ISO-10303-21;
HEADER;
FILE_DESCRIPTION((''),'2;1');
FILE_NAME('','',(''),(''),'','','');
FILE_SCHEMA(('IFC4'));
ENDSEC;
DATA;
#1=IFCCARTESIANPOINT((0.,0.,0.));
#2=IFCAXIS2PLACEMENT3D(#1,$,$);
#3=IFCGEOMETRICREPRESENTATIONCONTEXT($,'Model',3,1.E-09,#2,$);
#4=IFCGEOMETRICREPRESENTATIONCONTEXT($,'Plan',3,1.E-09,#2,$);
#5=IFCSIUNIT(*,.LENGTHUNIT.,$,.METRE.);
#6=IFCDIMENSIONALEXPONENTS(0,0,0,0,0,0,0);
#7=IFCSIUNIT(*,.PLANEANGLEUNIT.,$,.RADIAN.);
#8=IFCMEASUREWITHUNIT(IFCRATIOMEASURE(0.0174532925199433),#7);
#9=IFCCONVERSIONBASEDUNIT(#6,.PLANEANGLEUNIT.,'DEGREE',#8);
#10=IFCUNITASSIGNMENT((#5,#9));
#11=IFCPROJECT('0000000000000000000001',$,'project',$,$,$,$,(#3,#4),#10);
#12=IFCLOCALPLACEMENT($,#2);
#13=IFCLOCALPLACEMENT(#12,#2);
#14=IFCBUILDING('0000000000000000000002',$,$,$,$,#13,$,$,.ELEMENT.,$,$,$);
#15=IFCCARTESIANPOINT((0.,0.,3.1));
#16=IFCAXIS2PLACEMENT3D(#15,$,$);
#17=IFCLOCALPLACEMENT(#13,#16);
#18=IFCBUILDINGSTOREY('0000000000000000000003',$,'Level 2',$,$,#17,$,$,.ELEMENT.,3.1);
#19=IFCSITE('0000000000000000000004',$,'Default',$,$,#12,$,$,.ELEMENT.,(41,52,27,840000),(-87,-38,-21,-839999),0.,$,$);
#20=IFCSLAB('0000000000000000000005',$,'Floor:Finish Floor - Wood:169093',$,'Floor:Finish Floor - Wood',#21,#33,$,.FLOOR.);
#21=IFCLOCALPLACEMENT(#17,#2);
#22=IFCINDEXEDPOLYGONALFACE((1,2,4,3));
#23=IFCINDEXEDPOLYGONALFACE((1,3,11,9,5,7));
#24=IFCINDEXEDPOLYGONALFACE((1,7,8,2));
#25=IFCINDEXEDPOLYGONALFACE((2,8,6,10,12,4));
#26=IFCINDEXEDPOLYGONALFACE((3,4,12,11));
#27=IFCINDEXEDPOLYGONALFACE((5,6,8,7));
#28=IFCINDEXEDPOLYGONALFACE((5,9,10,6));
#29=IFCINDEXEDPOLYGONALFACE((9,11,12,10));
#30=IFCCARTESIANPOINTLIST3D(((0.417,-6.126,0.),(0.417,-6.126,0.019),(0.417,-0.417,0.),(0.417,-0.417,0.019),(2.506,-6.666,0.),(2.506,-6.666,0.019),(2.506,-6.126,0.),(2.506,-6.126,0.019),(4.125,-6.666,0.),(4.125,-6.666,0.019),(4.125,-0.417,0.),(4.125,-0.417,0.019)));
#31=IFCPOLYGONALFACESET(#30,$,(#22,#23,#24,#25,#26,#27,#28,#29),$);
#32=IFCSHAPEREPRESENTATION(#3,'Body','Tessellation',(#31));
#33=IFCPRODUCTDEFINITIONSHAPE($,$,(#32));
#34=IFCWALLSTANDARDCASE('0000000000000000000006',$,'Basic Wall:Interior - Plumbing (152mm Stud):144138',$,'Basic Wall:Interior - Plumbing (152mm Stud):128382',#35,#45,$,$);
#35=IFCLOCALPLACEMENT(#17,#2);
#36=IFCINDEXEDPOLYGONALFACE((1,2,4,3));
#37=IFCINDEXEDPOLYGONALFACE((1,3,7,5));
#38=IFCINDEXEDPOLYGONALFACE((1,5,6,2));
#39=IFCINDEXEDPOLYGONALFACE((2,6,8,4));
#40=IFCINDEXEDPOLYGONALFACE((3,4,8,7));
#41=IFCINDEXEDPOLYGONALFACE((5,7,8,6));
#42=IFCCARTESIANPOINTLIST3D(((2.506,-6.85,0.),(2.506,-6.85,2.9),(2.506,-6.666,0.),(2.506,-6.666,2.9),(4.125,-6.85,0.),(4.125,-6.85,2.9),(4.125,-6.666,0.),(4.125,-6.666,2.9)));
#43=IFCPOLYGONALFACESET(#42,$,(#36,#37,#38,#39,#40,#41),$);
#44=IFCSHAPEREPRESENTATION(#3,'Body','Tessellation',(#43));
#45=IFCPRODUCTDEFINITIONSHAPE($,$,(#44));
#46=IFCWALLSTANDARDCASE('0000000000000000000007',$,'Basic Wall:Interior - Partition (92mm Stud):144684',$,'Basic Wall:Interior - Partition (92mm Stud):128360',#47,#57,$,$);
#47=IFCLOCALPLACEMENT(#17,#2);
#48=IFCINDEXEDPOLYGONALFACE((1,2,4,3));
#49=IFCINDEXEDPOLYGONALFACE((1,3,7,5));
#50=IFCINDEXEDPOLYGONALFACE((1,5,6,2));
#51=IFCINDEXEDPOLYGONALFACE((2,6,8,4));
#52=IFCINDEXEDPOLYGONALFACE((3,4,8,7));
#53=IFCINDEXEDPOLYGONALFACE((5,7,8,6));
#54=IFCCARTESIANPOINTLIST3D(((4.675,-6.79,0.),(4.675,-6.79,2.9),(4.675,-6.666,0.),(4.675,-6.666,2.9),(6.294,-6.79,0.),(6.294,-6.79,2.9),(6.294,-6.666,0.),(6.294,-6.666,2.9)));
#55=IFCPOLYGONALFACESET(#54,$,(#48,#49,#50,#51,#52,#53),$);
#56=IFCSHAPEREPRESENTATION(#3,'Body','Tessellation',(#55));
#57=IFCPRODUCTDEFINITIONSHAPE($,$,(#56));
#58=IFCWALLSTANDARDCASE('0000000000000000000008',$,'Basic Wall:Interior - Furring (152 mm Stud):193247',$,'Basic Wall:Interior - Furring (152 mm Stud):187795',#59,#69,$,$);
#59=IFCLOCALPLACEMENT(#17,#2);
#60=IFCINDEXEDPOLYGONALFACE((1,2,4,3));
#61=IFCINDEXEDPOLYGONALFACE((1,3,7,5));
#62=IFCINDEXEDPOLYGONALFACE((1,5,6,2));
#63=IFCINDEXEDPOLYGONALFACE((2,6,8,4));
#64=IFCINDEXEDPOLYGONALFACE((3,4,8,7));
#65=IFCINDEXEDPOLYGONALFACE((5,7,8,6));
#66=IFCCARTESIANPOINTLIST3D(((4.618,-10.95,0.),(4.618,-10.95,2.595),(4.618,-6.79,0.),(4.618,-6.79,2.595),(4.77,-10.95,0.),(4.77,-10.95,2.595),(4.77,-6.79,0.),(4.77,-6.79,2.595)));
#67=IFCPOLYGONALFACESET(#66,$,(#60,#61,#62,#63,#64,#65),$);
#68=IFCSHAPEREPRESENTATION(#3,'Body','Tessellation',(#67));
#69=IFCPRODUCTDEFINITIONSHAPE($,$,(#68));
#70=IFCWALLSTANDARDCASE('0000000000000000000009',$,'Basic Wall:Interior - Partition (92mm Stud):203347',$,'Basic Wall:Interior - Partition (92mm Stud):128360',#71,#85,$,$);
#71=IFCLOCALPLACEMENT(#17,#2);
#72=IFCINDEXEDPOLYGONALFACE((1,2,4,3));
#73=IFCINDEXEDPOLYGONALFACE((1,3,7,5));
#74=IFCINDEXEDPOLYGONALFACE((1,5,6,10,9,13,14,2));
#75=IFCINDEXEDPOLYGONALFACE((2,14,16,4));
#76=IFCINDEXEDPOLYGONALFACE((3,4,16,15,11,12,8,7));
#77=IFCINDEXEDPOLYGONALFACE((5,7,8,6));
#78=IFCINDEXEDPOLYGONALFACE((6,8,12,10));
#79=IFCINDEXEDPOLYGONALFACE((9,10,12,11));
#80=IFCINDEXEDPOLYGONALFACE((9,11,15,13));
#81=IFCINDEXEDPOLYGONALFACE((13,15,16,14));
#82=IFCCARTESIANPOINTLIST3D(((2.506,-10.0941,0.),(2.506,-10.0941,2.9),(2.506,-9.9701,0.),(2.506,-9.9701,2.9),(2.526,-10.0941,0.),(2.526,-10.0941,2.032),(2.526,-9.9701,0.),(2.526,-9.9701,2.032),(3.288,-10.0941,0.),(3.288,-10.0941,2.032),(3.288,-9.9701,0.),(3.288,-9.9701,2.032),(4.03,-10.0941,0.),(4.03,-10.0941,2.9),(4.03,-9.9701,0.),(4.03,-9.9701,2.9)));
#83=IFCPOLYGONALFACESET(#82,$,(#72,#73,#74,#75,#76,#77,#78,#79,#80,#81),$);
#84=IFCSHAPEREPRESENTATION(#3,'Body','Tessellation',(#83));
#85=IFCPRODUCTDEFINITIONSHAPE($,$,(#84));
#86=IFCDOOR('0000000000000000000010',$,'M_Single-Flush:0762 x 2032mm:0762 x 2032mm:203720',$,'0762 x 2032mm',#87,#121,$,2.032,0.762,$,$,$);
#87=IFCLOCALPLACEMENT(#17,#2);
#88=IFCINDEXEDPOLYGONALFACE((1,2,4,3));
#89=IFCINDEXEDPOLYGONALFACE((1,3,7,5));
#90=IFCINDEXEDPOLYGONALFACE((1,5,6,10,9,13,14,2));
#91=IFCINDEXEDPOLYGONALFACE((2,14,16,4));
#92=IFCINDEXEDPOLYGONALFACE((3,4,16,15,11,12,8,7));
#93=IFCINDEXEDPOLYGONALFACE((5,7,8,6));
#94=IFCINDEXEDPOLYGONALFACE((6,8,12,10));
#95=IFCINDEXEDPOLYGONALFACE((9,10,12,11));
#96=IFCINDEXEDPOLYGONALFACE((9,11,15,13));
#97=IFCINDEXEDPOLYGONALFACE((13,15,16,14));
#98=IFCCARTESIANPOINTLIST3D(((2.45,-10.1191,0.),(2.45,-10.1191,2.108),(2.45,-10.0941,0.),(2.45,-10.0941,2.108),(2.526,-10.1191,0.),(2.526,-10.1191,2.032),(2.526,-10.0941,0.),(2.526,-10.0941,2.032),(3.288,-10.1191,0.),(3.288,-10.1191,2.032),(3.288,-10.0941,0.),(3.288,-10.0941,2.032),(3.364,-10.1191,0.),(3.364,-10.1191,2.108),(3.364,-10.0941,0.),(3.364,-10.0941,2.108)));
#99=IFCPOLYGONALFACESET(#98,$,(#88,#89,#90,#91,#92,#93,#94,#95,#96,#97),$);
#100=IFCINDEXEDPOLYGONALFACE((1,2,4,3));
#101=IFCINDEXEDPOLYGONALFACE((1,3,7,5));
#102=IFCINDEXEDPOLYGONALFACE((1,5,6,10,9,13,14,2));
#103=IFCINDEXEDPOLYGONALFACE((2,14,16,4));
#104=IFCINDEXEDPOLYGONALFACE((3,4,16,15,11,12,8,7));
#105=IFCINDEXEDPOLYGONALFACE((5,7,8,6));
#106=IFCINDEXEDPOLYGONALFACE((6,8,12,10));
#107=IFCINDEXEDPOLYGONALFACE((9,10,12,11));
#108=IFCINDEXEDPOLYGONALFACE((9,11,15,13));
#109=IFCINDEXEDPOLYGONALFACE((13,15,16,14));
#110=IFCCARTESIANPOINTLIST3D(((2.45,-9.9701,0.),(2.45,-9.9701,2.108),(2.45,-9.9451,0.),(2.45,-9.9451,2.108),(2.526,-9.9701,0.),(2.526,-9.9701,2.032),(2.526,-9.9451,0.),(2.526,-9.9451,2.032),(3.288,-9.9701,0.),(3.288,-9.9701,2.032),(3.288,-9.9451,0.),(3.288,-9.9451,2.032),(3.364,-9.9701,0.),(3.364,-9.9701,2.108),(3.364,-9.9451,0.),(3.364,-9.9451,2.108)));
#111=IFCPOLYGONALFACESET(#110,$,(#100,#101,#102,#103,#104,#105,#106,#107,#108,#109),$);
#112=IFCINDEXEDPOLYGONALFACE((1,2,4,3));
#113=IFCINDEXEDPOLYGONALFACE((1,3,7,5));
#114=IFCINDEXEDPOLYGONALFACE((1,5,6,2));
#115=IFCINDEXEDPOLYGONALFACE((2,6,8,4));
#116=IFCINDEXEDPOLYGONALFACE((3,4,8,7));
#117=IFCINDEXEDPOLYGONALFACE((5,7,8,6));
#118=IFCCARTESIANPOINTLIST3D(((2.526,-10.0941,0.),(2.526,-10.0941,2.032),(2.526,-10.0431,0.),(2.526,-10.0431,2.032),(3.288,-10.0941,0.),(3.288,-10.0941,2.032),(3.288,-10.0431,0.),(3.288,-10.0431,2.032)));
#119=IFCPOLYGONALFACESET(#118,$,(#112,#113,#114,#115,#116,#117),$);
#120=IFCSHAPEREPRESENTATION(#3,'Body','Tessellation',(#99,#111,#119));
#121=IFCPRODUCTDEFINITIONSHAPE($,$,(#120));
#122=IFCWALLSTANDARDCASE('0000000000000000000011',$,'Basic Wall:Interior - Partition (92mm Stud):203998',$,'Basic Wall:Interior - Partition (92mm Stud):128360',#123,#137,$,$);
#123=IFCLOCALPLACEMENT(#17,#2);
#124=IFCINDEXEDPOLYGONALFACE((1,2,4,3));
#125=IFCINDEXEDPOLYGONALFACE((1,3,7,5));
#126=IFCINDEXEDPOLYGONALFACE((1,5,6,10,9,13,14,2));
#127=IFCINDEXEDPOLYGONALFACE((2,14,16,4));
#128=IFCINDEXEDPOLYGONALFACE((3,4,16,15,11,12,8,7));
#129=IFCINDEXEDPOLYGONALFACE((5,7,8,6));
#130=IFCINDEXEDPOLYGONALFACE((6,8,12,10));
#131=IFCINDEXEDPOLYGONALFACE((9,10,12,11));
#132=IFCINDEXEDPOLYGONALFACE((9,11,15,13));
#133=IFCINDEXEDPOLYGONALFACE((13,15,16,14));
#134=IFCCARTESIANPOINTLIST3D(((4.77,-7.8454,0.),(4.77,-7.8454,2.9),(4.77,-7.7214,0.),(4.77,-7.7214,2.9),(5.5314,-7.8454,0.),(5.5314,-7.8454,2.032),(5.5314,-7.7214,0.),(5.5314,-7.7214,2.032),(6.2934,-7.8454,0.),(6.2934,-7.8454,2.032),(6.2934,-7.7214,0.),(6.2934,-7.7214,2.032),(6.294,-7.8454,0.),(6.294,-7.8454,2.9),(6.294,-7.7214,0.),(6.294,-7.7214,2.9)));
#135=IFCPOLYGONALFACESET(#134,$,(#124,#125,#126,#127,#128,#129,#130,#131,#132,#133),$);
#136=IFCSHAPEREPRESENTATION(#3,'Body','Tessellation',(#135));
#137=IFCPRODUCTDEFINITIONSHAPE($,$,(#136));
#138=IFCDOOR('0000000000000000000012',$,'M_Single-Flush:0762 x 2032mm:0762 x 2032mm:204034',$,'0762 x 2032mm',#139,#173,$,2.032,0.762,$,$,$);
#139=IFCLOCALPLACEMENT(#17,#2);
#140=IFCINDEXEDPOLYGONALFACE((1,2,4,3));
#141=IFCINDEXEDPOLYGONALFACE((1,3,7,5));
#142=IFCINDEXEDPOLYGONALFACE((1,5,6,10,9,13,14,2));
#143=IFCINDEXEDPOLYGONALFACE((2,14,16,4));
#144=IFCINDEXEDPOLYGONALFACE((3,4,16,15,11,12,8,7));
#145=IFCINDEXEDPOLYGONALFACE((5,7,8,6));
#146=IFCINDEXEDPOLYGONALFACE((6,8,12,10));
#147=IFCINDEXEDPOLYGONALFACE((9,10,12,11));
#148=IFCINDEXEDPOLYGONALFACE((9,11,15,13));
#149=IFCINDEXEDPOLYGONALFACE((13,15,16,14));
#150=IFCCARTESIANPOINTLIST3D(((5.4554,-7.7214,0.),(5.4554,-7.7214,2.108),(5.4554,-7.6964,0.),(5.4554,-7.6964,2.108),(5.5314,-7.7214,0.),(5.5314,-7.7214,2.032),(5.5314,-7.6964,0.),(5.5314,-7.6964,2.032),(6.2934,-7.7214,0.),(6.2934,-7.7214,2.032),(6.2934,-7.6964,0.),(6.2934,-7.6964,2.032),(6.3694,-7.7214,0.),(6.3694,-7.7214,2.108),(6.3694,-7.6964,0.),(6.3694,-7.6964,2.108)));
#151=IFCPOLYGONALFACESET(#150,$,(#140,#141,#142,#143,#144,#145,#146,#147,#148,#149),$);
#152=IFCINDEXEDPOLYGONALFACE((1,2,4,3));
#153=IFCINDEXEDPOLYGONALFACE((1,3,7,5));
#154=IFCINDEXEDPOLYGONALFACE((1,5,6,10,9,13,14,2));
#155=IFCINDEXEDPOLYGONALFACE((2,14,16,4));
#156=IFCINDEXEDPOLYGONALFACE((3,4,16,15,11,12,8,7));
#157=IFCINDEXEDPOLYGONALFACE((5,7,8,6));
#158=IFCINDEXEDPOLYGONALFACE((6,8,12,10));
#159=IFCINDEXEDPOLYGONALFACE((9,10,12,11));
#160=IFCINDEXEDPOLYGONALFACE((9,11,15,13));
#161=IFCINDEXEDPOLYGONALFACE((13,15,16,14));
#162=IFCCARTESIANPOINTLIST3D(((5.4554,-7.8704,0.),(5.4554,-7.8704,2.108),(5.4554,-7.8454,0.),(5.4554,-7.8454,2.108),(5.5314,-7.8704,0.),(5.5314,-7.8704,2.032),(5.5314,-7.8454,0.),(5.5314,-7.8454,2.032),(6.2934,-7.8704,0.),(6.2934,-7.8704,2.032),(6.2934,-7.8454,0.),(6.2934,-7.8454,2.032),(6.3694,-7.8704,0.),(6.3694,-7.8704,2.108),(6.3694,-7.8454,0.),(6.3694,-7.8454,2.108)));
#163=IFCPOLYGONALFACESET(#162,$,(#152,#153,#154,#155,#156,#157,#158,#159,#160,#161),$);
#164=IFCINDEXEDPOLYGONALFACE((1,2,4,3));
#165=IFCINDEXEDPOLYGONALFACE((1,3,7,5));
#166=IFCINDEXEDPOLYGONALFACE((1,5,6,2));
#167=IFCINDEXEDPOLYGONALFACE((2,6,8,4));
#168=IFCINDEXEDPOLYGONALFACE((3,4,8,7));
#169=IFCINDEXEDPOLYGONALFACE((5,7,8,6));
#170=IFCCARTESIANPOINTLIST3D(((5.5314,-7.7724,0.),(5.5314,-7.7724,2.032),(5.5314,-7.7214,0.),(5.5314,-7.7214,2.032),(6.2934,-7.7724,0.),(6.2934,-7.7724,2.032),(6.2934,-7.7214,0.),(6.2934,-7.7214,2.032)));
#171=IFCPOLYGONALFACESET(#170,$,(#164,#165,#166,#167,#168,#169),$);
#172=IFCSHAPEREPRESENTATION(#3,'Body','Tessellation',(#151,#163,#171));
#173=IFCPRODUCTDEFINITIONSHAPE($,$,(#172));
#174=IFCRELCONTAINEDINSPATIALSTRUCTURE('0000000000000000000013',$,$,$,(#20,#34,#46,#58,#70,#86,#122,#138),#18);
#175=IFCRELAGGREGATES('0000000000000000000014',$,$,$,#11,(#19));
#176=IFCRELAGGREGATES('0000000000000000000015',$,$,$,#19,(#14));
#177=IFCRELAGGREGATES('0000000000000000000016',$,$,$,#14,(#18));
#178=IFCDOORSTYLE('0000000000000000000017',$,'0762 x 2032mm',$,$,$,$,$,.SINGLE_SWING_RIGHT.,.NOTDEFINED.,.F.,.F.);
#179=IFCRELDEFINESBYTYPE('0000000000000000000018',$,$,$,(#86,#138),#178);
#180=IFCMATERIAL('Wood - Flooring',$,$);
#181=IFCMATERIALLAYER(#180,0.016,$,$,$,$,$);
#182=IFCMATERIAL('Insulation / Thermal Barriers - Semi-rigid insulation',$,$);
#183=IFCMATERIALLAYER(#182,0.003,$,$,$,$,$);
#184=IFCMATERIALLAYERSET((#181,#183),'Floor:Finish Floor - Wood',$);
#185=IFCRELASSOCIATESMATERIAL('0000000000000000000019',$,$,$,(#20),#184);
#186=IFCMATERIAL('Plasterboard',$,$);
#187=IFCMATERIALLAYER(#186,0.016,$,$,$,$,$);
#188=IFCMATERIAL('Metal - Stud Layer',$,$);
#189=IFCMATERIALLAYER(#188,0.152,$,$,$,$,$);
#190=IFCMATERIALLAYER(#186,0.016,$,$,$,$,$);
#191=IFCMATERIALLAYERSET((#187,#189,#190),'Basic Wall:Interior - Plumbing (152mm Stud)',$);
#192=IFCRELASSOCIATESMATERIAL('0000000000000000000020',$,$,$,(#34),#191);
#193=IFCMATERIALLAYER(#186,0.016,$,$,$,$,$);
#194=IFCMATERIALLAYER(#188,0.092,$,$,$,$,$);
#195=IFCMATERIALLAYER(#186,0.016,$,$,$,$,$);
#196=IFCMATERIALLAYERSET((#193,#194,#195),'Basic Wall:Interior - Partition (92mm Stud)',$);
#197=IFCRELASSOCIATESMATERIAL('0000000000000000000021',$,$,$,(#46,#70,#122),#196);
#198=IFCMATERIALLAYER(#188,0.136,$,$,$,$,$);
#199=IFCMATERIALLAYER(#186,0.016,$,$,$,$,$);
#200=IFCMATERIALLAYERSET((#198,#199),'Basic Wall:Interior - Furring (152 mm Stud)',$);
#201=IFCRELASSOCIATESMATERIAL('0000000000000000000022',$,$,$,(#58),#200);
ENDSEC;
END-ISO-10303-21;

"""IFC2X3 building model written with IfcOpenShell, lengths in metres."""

from ifc_helpers import new_model, entity, si_unit, converted_unit, frame, frame_2d, origin, origin_2d_with_axis, place, context, project, spatial, polyline, rectangle, outline, extrude, source, transform, mapped, material, layer, layer_set, layer_usage, type_object, type_shapes, element, fill, save


model = new_model("IFC2X3")

# Units and contexts
model_context = context("Model", 3, precision=1e-09, world=origin())
plan_context = context("Plan", 3, precision=1e-09, world=origin())
ifc_project = project(units=[si_unit("LENGTHUNIT", "METRE"), converted_unit("PLANEANGLEUNIT", "DEGREE", entity("IfcRatioMeasure", 0.0174532925199433), si_unit("PLANEANGLEUNIT", "RADIAN"), dimensions=[0, 0, 0, 0, 0, 0, 0])], contexts=[model_context, plan_context])

# Site, building, storey
site_placement = place(None, origin())
site = spatial("IfcSite", under=ifc_project, at=site_placement, Name="Default", CompositionType="ELEMENT", RefLatitude=(41, 52, 27, 840000), RefLongitude=(-87, -38, -21, -839999), RefElevation=0.0)
building_placement = place(site_placement, origin())
building = spatial("IfcBuilding", under=site, at=building_placement, CompositionType="ELEMENT")
storey_placement = place(building_placement, frame((0.0, 0.0, 3.1)))
storey = spatial("IfcBuildingStorey", under=building, at=storey_placement, Name="Level 2", CompositionType="ELEMENT", Elevation=3.1)

# Slab
ifc_material_1 = material(Name="Wood - Flooring")
ifc_layer_1 = layer(ifc_material_1, 0.016)
ifc_material_2 = material(Name="Insulation / Thermal Barriers - Semi-rigid insulation")
ifc_layer_2 = layer(ifc_material_2, 0.003)
ifc_layer_set_1 = layer_set([ifc_layer_1, ifc_layer_2], Name="Floor:Finish Floor - Wood")
ifc_layer_usage_1 = layer_usage(ifc_layer_set_1, "AXIS3", "POSITIVE", 0.0)
slab_placement = place(storey_placement, frame((0.417, -6.666, 0.0)))
element("IfcSlab", 1, at=slab_placement, inside=storey, material=ifc_layer_usage_1, Name="Floor:Finish Floor - Wood:169093", ObjectType="Floor:Finish Floor - Wood", PredefinedType="FLOOR", context=model_context, shape_type="SweptSolid", body=[
    extrude(outline(polyline([(1.854, 3.1245), (-1.854, 3.1245), (-1.854, -3.1245), (-0.235, -3.1245), (-0.235, -2.5845), (1.854, -2.5845), (1.854, 3.1245)])), frame((1.854, 3.1245, 0.019), z_axis=(0.0, 0.0, -1.0), x_axis=(-1.0, 0.0, 0.0)), (0.0, 0.0, 1.0), 0.019),
])

# Walls
ifc_material_3 = material(Name="Plasterboard")
ifc_layer_3 = layer(ifc_material_3, 0.016)
ifc_material_4 = material(Name="Metal - Stud Layer")
ifc_layer_4 = layer(ifc_material_4, 0.152)
ifc_layer_5 = layer(ifc_material_3, 0.016)
ifc_layer_set_2 = layer_set([ifc_layer_3, ifc_layer_4, ifc_layer_5], Name="Basic Wall:Interior - Plumbing (152mm Stud)")
ifc_layer_usage_2 = layer_usage(ifc_layer_set_2, "AXIS2", "NEGATIVE", 0.092)
wall_1_placement = place(storey_placement, frame((2.506, -6.758, 0.0)))
element("IfcWallStandardCase", 2, at=wall_1_placement, inside=storey, material=ifc_layer_usage_2, Name="Basic Wall:Interior - Plumbing (152mm Stud):144138", ObjectType="Basic Wall:Interior - Plumbing (152mm Stud):128382", context=model_context, shape_type="SweptSolid", body=[
    extrude(rectangle(XDim=1.619, YDim=0.184, at=frame_2d((0.8095, 0.0), x_axis=(-1.0, 0.0))), origin(), (0.0, 0.0, 1.0), 2.9),
])
ifc_layer_6 = layer(ifc_material_3, 0.016)
ifc_layer_7 = layer(ifc_material_4, 0.092)
ifc_layer_8 = layer(ifc_material_3, 0.016)
ifc_layer_set_3 = layer_set([ifc_layer_6, ifc_layer_7, ifc_layer_8], Name="Basic Wall:Interior - Partition (92mm Stud)")
ifc_layer_usage_3 = layer_usage(ifc_layer_set_3, "AXIS2", "NEGATIVE", 0.062)
wall_2_placement = place(storey_placement, frame((4.675, -6.728, 0.0)))
element("IfcWallStandardCase", 3, at=wall_2_placement, inside=storey, material=ifc_layer_usage_3, Name="Basic Wall:Interior - Partition (92mm Stud):144684", ObjectType="Basic Wall:Interior - Partition (92mm Stud):128360", context=model_context, shape_type="SweptSolid", body=[
    extrude(rectangle(XDim=1.619, YDim=0.124, at=frame_2d((0.8095, 0.0), x_axis=(-1.0, 0.0))), origin(), (0.0, 0.0, 1.0), 2.9),
])
ifc_layer_9 = layer(ifc_material_4, 0.136)
ifc_layer_10 = layer(ifc_material_3, 0.016)
ifc_layer_set_4 = layer_set([ifc_layer_9, ifc_layer_10], Name="Basic Wall:Interior - Furring (152 mm Stud)")
ifc_layer_usage_4 = layer_usage(ifc_layer_set_4, "AXIS2", "POSITIVE", -0.076)
wall_3_placement = place(storey_placement, frame((4.694, -6.79, 0.0), z_axis=(0.0, 0.0, 1.0), x_axis=(0.0, -1.0, 0.0)))
element("IfcWallStandardCase", 4, at=wall_3_placement, inside=storey, material=ifc_layer_usage_4, Name="Basic Wall:Interior - Furring (152 mm Stud):193247", ObjectType="Basic Wall:Interior - Furring (152 mm Stud):187795", context=model_context, shape_type="SweptSolid", body=[
    extrude(rectangle(XDim=4.16, YDim=0.152, at=frame_2d((2.08, 0.0), x_axis=(-1.0, 0.0))), origin(), (0.0, 0.0, 1.0), 2.595),
])

# Walls, openings, doors
ifc_layer_usage_5 = layer_usage(ifc_layer_set_3, "AXIS2", "NEGATIVE", 0.062)
wall_4_placement = place(storey_placement, frame((4.03, -10.0321, 0.0), z_axis=(0.0, 0.0, 1.0), x_axis=(-1.0, 0.0, 0.0)))
wall_4 = element("IfcWallStandardCase", 5, at=wall_4_placement, inside=storey, material=ifc_layer_usage_5, Name="Basic Wall:Interior - Partition (92mm Stud):203347", ObjectType="Basic Wall:Interior - Partition (92mm Stud):128360", context=model_context, shape_type="SweptSolid", body=[
    extrude(rectangle(XDim=1.524, YDim=0.124, at=frame_2d((0.762, 0.0), x_axis=(-1.0, 0.0))), origin(), (0.0, 0.0, 1.0), 2.9),
])
opening_1_placement = place(wall_4_placement, frame((0.742, -0.062, 0.0)))
opening_1 = element("IfcOpeningElement", 6, at=opening_1_placement, cuts=wall_4, ObjectType="Opening", context=model_context, shape_type="SweptSolid", body=[
    extrude(rectangle(XDim=0.762, YDim=2.032, at=frame_2d((1.016, 0.381), x_axis=(0.0, 1.0))), frame((0.0, 0.0, 0.0), z_axis=(0.0, 1.0, 0.0), x_axis=(0.0, 0.0, 1.0)), (0.0, 0.0, 1.0), 0.124),
])
door_style = type_object("IfcDoorStyle", Name="0762 x 2032mm", ConstructionType="NOTDEFINED", OperationType="SINGLE_SWING_RIGHT", ParameterTakesPrecedence=False, Sizeable=False)
shared_shape = source(origin(), model_context, "Body", "SweptSolid", [
    extrude(outline(polyline([(-0.457, -1.073), (0.457, -1.073), (0.457, 1.035), (0.381, 1.035), (0.381, -0.997), (-0.381, -0.997), (-0.381, 1.035), (-0.457, 1.035), (-0.457, -1.073)])), frame((0.381, 0.124, 1.035), z_axis=(0.0, 1.0, 0.0), x_axis=(1.0, 0.0, 0.0)), (0.0, 0.0, 1.0), 0.025),
    extrude(outline(polyline([(-1.073, -0.457), (1.035, -0.457), (1.035, -0.381), (-0.997, -0.381), (-0.997, 0.381), (1.035, 0.381), (1.035, 0.457), (-1.073, 0.457), (-1.073, -0.457)])), frame((0.381, -0.025, 1.035), z_axis=(0.0, 1.0, 0.0), x_axis=(0.0, 0.0, -1.0)), (0.0, 0.0, 1.0), 0.025),
    extrude(rectangle(XDim=0.051, YDim=0.762, at=origin_2d_with_axis()), frame((0.381, 0.0985, 0.0), z_axis=(0.0, 0.0, 1.0), x_axis=(0.0, 1.0, 0.0)), (0.0, 0.0, 1.0), 2.032),
])
type_shapes(door_style, [shared_shape])
door_1_placement = place(opening_1_placement, origin())
door_1 = element("IfcDoor", 7, at=door_1_placement, inside=storey, type_object=door_style, Name="M_Single-Flush:0762 x 2032mm:0762 x 2032mm:203720", ObjectType="0762 x 2032mm", OverallHeight=2.032, OverallWidth=0.762, context=model_context, shape_type="MappedRepresentation", body=[
    mapped(shared_shape, transform((0.0, 0.0, 0.0), scale=1.0)),
])
fill(opening_1, door_1)
ifc_layer_usage_6 = layer_usage(ifc_layer_set_3, "AXIS2", "POSITIVE", -0.062)
wall_5_placement = place(storey_placement, frame((4.77, -7.7834, 0.0)))
wall_5 = element("IfcWallStandardCase", 8, at=wall_5_placement, inside=storey, material=ifc_layer_usage_6, Name="Basic Wall:Interior - Partition (92mm Stud):203998", ObjectType="Basic Wall:Interior - Partition (92mm Stud):128360", context=model_context, shape_type="SweptSolid", body=[
    extrude(rectangle(XDim=1.524, YDim=0.124, at=frame_2d((0.762, 0.0), x_axis=(-1.0, 0.0))), origin(), (0.0, 0.0, 1.0), 2.9),
])
opening_2_placement = place(wall_5_placement, frame((0.7614, -0.062, 0.0)))
opening_2 = element("IfcOpeningElement", 9, at=opening_2_placement, cuts=wall_5, ObjectType="Opening", context=model_context, shape_type="SweptSolid", body=[
    extrude(rectangle(XDim=0.762, YDim=2.032, at=frame_2d((1.016, 0.381), x_axis=(0.0, 1.0))), frame((0.0, 0.0, 0.0), z_axis=(0.0, 1.0, 0.0), x_axis=(0.0, 0.0, 1.0)), (0.0, 0.0, 1.0), 0.124),
])
door_2_placement = place(opening_2_placement, origin())
door_2 = element("IfcDoor", 10, at=door_2_placement, inside=storey, type_object=door_style, Name="M_Single-Flush:0762 x 2032mm:0762 x 2032mm:204034", ObjectType="0762 x 2032mm", OverallHeight=2.032, OverallWidth=0.762, context=model_context, shape_type="MappedRepresentation", body=[
    mapped(shared_shape, transform((0.0, 0.0, 0.0), scale=1.0)),
])
fill(opening_2, door_2)

save(model, "model.ifc")
